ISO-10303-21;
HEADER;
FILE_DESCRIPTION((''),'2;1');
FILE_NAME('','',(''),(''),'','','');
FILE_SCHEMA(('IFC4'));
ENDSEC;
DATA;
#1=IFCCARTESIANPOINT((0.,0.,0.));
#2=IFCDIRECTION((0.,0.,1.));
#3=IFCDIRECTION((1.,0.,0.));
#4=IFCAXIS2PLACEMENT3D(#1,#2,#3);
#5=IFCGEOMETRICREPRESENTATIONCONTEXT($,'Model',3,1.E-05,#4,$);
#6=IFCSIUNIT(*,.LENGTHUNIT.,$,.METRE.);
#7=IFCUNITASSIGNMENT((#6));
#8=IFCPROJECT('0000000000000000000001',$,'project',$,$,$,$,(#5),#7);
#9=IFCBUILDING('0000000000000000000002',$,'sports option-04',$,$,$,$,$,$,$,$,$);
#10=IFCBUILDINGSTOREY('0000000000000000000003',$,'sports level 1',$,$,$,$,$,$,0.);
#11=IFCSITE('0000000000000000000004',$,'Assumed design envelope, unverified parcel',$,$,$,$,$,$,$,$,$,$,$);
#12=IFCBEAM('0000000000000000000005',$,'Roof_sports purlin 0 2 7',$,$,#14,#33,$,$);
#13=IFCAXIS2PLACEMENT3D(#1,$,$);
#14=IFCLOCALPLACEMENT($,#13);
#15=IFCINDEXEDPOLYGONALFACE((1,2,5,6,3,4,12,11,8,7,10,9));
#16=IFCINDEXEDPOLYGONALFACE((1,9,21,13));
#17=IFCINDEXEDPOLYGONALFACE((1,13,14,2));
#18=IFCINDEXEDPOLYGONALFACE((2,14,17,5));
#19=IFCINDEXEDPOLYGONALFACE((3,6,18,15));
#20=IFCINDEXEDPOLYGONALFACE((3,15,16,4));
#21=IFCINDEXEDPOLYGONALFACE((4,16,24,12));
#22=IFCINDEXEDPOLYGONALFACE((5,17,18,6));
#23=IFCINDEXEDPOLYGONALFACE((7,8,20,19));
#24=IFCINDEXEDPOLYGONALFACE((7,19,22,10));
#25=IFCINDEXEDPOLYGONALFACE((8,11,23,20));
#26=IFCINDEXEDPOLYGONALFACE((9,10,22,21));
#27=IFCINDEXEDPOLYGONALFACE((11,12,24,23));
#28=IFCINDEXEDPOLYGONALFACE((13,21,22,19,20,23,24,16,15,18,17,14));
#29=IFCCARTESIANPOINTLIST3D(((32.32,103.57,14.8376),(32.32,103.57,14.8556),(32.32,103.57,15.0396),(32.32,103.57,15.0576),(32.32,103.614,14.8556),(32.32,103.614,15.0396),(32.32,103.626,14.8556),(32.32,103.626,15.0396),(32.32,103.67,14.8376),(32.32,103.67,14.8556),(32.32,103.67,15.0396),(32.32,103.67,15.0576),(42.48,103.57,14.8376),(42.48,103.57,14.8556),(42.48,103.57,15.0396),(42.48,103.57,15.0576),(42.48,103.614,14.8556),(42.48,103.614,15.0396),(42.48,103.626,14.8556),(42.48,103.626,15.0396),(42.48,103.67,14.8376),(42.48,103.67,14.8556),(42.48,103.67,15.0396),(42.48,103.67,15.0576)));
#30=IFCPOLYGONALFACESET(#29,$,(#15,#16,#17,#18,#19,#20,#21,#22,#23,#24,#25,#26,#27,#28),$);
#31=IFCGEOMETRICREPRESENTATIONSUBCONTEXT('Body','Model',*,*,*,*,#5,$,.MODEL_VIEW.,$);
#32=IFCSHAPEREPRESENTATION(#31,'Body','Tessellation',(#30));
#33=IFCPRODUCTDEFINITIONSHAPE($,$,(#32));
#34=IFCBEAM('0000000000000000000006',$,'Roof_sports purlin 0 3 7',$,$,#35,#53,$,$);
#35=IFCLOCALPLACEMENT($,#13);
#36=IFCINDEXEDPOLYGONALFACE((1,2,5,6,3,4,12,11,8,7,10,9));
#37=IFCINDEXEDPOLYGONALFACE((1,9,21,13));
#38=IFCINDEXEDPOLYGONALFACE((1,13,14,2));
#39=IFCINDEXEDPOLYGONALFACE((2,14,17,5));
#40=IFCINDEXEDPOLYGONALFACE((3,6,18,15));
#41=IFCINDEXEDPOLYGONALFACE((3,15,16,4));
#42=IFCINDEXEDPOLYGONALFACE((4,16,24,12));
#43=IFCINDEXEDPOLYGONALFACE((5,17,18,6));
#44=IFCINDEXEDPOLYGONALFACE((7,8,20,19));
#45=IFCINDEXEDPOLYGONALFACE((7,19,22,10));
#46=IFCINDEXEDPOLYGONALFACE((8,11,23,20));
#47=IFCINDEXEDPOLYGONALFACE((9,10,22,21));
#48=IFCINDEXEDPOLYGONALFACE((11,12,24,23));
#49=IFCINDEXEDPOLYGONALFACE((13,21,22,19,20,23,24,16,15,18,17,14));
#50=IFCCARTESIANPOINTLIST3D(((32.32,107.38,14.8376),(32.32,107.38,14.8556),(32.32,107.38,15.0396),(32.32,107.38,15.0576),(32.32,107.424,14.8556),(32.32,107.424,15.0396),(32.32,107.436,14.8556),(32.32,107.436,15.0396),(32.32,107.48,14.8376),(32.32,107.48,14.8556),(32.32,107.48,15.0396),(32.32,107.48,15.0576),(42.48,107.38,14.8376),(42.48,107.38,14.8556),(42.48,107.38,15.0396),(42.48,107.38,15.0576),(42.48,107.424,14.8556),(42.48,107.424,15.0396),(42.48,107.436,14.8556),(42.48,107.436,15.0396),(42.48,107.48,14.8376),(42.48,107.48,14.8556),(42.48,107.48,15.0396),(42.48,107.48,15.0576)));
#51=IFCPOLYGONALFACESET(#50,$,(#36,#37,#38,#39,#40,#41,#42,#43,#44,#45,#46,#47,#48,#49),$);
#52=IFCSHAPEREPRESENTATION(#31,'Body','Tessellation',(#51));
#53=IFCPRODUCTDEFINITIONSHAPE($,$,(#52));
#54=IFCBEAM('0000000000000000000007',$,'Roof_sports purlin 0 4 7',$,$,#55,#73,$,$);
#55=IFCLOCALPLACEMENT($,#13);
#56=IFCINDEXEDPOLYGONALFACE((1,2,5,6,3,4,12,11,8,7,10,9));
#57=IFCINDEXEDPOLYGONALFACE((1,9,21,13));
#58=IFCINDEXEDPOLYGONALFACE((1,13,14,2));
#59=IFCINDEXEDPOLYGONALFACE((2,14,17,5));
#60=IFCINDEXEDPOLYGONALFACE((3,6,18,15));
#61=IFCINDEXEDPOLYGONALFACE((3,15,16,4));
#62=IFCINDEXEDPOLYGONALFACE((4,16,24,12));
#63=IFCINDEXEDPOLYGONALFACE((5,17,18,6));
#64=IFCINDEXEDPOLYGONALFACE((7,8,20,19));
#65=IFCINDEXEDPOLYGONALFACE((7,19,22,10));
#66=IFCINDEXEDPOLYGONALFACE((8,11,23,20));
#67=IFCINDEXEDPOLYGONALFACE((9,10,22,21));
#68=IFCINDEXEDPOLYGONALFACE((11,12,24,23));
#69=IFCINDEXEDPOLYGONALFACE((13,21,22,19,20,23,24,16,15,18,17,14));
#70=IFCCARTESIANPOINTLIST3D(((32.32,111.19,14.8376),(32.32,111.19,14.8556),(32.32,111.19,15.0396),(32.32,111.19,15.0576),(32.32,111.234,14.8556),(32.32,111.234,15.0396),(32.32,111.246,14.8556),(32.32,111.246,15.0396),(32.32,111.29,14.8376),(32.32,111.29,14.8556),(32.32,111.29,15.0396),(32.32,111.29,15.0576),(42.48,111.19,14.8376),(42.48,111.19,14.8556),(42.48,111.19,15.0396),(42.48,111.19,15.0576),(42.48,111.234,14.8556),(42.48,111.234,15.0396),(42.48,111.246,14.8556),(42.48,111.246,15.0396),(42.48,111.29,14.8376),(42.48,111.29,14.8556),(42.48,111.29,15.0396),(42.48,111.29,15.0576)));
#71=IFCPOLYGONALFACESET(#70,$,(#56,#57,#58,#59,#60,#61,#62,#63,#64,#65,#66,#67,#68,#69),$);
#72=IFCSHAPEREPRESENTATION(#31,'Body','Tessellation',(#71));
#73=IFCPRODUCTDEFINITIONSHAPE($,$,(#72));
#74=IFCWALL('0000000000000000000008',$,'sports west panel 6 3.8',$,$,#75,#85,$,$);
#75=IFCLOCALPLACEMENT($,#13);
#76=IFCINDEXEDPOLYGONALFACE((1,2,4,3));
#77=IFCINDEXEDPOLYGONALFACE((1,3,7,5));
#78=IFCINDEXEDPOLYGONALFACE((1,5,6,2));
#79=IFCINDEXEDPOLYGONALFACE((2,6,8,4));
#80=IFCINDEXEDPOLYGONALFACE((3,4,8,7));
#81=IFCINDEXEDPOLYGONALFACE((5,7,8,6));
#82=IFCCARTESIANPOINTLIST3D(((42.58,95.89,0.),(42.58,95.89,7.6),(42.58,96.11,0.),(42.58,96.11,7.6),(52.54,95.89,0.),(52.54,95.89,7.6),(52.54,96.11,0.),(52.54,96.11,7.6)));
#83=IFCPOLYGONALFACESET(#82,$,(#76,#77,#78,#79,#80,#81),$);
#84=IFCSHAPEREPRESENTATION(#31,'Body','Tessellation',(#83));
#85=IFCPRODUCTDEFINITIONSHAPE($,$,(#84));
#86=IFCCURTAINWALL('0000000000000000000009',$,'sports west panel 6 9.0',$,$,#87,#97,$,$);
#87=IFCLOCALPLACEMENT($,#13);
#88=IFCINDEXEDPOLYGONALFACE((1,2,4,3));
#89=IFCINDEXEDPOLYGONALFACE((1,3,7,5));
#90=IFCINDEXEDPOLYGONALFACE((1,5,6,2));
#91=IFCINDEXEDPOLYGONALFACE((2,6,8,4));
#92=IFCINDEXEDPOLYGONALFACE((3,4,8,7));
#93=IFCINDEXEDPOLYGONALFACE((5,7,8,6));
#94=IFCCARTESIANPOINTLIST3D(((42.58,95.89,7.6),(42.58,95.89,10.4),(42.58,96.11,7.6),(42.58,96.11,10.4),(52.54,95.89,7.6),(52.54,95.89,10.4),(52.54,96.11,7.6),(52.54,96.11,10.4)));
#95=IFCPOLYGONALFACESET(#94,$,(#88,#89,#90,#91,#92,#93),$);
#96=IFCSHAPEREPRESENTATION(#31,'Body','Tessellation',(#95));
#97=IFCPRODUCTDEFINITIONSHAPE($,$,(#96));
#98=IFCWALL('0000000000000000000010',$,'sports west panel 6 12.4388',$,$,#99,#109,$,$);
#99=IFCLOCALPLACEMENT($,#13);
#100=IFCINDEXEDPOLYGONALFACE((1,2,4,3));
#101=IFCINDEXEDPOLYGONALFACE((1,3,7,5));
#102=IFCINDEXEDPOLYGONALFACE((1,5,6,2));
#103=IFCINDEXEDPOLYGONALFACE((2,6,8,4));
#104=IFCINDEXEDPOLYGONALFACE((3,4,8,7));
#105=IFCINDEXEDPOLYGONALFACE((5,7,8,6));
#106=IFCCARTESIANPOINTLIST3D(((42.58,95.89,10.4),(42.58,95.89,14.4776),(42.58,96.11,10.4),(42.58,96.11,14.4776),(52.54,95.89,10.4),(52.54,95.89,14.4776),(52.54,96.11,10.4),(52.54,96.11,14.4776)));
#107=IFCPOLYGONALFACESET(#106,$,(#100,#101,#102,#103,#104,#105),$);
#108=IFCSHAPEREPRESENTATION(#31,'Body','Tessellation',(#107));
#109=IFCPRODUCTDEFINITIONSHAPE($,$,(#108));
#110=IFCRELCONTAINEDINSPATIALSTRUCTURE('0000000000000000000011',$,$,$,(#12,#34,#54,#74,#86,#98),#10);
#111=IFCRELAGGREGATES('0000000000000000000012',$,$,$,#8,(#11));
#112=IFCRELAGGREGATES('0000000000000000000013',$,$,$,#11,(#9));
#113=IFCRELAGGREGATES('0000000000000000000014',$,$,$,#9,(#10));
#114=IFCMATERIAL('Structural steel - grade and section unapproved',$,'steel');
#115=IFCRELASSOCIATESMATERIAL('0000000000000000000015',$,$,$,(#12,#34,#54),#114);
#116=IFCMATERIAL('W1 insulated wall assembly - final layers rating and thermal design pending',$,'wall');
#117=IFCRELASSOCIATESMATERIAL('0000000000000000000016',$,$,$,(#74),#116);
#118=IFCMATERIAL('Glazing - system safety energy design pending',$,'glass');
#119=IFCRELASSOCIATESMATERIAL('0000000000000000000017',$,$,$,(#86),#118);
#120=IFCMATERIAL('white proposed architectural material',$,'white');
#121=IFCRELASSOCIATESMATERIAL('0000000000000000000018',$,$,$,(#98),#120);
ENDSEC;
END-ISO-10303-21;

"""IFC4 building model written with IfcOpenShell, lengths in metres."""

from ifc_helpers import new_model, si_unit, frame, origin_with_axes, place, context, subcontext, project, spatial, rectangle, i_section, extrude, material, element, save


model = new_model("IFC4")

# Units and contexts
model_context = context("Model", 3, precision=1e-05, world=origin_with_axes())
body_context = subcontext(model_context, "Body", "Model", "MODEL_VIEW")
ifc_project = project(units=[si_unit("LENGTHUNIT", "METRE")], contexts=[model_context])

# Site, building, storey
site = spatial("IfcSite", under=ifc_project, Name="Assumed design envelope, unverified parcel")
building = spatial("IfcBuilding", under=site, Name="sports option-04")
storey = spatial("IfcBuildingStorey", under=building, Name="sports level 1", Elevation=0.0)

# Shared definitions
ifc_material_1 = material(Name="Structural steel - grade and section unapproved", Category="steel")

# Beams
for number, where, z_axis, x_axis, name in (
    (1, (42.48, 103.62, 14.9476), (-1.0, 0.0, 0.0), (0.0, -1.0, 0.0), "Roof_sports purlin 0 2 7"),
    (2, (42.48, 107.43, 14.9476), (-1.0, 0.0, 0.0), (0.0, -1.0, 0.0), "Roof_sports purlin 0 3 7"),
    (3, (42.48, 111.24, 14.9476), (-1.0, 0.0, 0.0), (0.0, -1.0, 0.0), "Roof_sports purlin 0 4 7"),
):
    element("IfcBeam", number, at=place(None, frame(where, z_axis=z_axis, x_axis=x_axis)), inside=storey, material=ifc_material_1, Name=name, context=body_context, shape_type="SweptSolid", body=[
        extrude(i_section(OverallWidth=0.1, OverallDepth=0.22, WebThickness=0.012, FlangeThickness=0.018, FilletRadius=0.0), origin_with_axes(), (0.0, 0.0, 1.0), 10.16),
    ])

# Wall
ifc_material_2 = material(Name="W1 insulated wall assembly - final layers rating and thermal design pending", Category="wall")
wall_1_placement = place(None, frame((47.56, 96.0, 0.0), z_axis=(0.0, 0.0, 1.0), x_axis=(0.0, 1.0, 0.0)))
element("IfcWall", 4, at=wall_1_placement, inside=storey, material=ifc_material_2, Name="sports west panel 6 3.8", context=body_context, shape_type="SweptSolid", body=[
    extrude(rectangle(XDim=0.22, YDim=9.96), origin_with_axes(), (0.0, 0.0, 1.0), 7.6),
])

# Curtain wall
ifc_material_3 = material(Name="Glazing - system safety energy design pending", Category="glass")
curtain_wall_placement = place(None, frame((47.56, 96.0, 7.6), z_axis=(0.0, 0.0, 1.0), x_axis=(0.0, 1.0, 0.0)))
element("IfcCurtainWall", 5, at=curtain_wall_placement, inside=storey, material=ifc_material_3, Name="sports west panel 6 9.0", context=body_context, shape_type="SweptSolid", body=[
    extrude(rectangle(XDim=0.22, YDim=9.96), origin_with_axes(), (0.0, 0.0, 1.0), 2.8),
])

# Wall
ifc_material_4 = material(Name="white proposed architectural material", Category="white")
wall_2_placement = place(None, frame((47.56, 96.0, 10.4), z_axis=(0.0, 0.0, 1.0), x_axis=(0.0, 1.0, 0.0)))
element("IfcWall", 6, at=wall_2_placement, inside=storey, material=ifc_material_4, Name="sports west panel 6 12.4388", context=body_context, shape_type="SweptSolid", body=[
    extrude(rectangle(XDim=0.22, YDim=9.96), origin_with_axes(), (0.0, 0.0, 1.0), 4.0776),
])

save(model, "model.ifc")
